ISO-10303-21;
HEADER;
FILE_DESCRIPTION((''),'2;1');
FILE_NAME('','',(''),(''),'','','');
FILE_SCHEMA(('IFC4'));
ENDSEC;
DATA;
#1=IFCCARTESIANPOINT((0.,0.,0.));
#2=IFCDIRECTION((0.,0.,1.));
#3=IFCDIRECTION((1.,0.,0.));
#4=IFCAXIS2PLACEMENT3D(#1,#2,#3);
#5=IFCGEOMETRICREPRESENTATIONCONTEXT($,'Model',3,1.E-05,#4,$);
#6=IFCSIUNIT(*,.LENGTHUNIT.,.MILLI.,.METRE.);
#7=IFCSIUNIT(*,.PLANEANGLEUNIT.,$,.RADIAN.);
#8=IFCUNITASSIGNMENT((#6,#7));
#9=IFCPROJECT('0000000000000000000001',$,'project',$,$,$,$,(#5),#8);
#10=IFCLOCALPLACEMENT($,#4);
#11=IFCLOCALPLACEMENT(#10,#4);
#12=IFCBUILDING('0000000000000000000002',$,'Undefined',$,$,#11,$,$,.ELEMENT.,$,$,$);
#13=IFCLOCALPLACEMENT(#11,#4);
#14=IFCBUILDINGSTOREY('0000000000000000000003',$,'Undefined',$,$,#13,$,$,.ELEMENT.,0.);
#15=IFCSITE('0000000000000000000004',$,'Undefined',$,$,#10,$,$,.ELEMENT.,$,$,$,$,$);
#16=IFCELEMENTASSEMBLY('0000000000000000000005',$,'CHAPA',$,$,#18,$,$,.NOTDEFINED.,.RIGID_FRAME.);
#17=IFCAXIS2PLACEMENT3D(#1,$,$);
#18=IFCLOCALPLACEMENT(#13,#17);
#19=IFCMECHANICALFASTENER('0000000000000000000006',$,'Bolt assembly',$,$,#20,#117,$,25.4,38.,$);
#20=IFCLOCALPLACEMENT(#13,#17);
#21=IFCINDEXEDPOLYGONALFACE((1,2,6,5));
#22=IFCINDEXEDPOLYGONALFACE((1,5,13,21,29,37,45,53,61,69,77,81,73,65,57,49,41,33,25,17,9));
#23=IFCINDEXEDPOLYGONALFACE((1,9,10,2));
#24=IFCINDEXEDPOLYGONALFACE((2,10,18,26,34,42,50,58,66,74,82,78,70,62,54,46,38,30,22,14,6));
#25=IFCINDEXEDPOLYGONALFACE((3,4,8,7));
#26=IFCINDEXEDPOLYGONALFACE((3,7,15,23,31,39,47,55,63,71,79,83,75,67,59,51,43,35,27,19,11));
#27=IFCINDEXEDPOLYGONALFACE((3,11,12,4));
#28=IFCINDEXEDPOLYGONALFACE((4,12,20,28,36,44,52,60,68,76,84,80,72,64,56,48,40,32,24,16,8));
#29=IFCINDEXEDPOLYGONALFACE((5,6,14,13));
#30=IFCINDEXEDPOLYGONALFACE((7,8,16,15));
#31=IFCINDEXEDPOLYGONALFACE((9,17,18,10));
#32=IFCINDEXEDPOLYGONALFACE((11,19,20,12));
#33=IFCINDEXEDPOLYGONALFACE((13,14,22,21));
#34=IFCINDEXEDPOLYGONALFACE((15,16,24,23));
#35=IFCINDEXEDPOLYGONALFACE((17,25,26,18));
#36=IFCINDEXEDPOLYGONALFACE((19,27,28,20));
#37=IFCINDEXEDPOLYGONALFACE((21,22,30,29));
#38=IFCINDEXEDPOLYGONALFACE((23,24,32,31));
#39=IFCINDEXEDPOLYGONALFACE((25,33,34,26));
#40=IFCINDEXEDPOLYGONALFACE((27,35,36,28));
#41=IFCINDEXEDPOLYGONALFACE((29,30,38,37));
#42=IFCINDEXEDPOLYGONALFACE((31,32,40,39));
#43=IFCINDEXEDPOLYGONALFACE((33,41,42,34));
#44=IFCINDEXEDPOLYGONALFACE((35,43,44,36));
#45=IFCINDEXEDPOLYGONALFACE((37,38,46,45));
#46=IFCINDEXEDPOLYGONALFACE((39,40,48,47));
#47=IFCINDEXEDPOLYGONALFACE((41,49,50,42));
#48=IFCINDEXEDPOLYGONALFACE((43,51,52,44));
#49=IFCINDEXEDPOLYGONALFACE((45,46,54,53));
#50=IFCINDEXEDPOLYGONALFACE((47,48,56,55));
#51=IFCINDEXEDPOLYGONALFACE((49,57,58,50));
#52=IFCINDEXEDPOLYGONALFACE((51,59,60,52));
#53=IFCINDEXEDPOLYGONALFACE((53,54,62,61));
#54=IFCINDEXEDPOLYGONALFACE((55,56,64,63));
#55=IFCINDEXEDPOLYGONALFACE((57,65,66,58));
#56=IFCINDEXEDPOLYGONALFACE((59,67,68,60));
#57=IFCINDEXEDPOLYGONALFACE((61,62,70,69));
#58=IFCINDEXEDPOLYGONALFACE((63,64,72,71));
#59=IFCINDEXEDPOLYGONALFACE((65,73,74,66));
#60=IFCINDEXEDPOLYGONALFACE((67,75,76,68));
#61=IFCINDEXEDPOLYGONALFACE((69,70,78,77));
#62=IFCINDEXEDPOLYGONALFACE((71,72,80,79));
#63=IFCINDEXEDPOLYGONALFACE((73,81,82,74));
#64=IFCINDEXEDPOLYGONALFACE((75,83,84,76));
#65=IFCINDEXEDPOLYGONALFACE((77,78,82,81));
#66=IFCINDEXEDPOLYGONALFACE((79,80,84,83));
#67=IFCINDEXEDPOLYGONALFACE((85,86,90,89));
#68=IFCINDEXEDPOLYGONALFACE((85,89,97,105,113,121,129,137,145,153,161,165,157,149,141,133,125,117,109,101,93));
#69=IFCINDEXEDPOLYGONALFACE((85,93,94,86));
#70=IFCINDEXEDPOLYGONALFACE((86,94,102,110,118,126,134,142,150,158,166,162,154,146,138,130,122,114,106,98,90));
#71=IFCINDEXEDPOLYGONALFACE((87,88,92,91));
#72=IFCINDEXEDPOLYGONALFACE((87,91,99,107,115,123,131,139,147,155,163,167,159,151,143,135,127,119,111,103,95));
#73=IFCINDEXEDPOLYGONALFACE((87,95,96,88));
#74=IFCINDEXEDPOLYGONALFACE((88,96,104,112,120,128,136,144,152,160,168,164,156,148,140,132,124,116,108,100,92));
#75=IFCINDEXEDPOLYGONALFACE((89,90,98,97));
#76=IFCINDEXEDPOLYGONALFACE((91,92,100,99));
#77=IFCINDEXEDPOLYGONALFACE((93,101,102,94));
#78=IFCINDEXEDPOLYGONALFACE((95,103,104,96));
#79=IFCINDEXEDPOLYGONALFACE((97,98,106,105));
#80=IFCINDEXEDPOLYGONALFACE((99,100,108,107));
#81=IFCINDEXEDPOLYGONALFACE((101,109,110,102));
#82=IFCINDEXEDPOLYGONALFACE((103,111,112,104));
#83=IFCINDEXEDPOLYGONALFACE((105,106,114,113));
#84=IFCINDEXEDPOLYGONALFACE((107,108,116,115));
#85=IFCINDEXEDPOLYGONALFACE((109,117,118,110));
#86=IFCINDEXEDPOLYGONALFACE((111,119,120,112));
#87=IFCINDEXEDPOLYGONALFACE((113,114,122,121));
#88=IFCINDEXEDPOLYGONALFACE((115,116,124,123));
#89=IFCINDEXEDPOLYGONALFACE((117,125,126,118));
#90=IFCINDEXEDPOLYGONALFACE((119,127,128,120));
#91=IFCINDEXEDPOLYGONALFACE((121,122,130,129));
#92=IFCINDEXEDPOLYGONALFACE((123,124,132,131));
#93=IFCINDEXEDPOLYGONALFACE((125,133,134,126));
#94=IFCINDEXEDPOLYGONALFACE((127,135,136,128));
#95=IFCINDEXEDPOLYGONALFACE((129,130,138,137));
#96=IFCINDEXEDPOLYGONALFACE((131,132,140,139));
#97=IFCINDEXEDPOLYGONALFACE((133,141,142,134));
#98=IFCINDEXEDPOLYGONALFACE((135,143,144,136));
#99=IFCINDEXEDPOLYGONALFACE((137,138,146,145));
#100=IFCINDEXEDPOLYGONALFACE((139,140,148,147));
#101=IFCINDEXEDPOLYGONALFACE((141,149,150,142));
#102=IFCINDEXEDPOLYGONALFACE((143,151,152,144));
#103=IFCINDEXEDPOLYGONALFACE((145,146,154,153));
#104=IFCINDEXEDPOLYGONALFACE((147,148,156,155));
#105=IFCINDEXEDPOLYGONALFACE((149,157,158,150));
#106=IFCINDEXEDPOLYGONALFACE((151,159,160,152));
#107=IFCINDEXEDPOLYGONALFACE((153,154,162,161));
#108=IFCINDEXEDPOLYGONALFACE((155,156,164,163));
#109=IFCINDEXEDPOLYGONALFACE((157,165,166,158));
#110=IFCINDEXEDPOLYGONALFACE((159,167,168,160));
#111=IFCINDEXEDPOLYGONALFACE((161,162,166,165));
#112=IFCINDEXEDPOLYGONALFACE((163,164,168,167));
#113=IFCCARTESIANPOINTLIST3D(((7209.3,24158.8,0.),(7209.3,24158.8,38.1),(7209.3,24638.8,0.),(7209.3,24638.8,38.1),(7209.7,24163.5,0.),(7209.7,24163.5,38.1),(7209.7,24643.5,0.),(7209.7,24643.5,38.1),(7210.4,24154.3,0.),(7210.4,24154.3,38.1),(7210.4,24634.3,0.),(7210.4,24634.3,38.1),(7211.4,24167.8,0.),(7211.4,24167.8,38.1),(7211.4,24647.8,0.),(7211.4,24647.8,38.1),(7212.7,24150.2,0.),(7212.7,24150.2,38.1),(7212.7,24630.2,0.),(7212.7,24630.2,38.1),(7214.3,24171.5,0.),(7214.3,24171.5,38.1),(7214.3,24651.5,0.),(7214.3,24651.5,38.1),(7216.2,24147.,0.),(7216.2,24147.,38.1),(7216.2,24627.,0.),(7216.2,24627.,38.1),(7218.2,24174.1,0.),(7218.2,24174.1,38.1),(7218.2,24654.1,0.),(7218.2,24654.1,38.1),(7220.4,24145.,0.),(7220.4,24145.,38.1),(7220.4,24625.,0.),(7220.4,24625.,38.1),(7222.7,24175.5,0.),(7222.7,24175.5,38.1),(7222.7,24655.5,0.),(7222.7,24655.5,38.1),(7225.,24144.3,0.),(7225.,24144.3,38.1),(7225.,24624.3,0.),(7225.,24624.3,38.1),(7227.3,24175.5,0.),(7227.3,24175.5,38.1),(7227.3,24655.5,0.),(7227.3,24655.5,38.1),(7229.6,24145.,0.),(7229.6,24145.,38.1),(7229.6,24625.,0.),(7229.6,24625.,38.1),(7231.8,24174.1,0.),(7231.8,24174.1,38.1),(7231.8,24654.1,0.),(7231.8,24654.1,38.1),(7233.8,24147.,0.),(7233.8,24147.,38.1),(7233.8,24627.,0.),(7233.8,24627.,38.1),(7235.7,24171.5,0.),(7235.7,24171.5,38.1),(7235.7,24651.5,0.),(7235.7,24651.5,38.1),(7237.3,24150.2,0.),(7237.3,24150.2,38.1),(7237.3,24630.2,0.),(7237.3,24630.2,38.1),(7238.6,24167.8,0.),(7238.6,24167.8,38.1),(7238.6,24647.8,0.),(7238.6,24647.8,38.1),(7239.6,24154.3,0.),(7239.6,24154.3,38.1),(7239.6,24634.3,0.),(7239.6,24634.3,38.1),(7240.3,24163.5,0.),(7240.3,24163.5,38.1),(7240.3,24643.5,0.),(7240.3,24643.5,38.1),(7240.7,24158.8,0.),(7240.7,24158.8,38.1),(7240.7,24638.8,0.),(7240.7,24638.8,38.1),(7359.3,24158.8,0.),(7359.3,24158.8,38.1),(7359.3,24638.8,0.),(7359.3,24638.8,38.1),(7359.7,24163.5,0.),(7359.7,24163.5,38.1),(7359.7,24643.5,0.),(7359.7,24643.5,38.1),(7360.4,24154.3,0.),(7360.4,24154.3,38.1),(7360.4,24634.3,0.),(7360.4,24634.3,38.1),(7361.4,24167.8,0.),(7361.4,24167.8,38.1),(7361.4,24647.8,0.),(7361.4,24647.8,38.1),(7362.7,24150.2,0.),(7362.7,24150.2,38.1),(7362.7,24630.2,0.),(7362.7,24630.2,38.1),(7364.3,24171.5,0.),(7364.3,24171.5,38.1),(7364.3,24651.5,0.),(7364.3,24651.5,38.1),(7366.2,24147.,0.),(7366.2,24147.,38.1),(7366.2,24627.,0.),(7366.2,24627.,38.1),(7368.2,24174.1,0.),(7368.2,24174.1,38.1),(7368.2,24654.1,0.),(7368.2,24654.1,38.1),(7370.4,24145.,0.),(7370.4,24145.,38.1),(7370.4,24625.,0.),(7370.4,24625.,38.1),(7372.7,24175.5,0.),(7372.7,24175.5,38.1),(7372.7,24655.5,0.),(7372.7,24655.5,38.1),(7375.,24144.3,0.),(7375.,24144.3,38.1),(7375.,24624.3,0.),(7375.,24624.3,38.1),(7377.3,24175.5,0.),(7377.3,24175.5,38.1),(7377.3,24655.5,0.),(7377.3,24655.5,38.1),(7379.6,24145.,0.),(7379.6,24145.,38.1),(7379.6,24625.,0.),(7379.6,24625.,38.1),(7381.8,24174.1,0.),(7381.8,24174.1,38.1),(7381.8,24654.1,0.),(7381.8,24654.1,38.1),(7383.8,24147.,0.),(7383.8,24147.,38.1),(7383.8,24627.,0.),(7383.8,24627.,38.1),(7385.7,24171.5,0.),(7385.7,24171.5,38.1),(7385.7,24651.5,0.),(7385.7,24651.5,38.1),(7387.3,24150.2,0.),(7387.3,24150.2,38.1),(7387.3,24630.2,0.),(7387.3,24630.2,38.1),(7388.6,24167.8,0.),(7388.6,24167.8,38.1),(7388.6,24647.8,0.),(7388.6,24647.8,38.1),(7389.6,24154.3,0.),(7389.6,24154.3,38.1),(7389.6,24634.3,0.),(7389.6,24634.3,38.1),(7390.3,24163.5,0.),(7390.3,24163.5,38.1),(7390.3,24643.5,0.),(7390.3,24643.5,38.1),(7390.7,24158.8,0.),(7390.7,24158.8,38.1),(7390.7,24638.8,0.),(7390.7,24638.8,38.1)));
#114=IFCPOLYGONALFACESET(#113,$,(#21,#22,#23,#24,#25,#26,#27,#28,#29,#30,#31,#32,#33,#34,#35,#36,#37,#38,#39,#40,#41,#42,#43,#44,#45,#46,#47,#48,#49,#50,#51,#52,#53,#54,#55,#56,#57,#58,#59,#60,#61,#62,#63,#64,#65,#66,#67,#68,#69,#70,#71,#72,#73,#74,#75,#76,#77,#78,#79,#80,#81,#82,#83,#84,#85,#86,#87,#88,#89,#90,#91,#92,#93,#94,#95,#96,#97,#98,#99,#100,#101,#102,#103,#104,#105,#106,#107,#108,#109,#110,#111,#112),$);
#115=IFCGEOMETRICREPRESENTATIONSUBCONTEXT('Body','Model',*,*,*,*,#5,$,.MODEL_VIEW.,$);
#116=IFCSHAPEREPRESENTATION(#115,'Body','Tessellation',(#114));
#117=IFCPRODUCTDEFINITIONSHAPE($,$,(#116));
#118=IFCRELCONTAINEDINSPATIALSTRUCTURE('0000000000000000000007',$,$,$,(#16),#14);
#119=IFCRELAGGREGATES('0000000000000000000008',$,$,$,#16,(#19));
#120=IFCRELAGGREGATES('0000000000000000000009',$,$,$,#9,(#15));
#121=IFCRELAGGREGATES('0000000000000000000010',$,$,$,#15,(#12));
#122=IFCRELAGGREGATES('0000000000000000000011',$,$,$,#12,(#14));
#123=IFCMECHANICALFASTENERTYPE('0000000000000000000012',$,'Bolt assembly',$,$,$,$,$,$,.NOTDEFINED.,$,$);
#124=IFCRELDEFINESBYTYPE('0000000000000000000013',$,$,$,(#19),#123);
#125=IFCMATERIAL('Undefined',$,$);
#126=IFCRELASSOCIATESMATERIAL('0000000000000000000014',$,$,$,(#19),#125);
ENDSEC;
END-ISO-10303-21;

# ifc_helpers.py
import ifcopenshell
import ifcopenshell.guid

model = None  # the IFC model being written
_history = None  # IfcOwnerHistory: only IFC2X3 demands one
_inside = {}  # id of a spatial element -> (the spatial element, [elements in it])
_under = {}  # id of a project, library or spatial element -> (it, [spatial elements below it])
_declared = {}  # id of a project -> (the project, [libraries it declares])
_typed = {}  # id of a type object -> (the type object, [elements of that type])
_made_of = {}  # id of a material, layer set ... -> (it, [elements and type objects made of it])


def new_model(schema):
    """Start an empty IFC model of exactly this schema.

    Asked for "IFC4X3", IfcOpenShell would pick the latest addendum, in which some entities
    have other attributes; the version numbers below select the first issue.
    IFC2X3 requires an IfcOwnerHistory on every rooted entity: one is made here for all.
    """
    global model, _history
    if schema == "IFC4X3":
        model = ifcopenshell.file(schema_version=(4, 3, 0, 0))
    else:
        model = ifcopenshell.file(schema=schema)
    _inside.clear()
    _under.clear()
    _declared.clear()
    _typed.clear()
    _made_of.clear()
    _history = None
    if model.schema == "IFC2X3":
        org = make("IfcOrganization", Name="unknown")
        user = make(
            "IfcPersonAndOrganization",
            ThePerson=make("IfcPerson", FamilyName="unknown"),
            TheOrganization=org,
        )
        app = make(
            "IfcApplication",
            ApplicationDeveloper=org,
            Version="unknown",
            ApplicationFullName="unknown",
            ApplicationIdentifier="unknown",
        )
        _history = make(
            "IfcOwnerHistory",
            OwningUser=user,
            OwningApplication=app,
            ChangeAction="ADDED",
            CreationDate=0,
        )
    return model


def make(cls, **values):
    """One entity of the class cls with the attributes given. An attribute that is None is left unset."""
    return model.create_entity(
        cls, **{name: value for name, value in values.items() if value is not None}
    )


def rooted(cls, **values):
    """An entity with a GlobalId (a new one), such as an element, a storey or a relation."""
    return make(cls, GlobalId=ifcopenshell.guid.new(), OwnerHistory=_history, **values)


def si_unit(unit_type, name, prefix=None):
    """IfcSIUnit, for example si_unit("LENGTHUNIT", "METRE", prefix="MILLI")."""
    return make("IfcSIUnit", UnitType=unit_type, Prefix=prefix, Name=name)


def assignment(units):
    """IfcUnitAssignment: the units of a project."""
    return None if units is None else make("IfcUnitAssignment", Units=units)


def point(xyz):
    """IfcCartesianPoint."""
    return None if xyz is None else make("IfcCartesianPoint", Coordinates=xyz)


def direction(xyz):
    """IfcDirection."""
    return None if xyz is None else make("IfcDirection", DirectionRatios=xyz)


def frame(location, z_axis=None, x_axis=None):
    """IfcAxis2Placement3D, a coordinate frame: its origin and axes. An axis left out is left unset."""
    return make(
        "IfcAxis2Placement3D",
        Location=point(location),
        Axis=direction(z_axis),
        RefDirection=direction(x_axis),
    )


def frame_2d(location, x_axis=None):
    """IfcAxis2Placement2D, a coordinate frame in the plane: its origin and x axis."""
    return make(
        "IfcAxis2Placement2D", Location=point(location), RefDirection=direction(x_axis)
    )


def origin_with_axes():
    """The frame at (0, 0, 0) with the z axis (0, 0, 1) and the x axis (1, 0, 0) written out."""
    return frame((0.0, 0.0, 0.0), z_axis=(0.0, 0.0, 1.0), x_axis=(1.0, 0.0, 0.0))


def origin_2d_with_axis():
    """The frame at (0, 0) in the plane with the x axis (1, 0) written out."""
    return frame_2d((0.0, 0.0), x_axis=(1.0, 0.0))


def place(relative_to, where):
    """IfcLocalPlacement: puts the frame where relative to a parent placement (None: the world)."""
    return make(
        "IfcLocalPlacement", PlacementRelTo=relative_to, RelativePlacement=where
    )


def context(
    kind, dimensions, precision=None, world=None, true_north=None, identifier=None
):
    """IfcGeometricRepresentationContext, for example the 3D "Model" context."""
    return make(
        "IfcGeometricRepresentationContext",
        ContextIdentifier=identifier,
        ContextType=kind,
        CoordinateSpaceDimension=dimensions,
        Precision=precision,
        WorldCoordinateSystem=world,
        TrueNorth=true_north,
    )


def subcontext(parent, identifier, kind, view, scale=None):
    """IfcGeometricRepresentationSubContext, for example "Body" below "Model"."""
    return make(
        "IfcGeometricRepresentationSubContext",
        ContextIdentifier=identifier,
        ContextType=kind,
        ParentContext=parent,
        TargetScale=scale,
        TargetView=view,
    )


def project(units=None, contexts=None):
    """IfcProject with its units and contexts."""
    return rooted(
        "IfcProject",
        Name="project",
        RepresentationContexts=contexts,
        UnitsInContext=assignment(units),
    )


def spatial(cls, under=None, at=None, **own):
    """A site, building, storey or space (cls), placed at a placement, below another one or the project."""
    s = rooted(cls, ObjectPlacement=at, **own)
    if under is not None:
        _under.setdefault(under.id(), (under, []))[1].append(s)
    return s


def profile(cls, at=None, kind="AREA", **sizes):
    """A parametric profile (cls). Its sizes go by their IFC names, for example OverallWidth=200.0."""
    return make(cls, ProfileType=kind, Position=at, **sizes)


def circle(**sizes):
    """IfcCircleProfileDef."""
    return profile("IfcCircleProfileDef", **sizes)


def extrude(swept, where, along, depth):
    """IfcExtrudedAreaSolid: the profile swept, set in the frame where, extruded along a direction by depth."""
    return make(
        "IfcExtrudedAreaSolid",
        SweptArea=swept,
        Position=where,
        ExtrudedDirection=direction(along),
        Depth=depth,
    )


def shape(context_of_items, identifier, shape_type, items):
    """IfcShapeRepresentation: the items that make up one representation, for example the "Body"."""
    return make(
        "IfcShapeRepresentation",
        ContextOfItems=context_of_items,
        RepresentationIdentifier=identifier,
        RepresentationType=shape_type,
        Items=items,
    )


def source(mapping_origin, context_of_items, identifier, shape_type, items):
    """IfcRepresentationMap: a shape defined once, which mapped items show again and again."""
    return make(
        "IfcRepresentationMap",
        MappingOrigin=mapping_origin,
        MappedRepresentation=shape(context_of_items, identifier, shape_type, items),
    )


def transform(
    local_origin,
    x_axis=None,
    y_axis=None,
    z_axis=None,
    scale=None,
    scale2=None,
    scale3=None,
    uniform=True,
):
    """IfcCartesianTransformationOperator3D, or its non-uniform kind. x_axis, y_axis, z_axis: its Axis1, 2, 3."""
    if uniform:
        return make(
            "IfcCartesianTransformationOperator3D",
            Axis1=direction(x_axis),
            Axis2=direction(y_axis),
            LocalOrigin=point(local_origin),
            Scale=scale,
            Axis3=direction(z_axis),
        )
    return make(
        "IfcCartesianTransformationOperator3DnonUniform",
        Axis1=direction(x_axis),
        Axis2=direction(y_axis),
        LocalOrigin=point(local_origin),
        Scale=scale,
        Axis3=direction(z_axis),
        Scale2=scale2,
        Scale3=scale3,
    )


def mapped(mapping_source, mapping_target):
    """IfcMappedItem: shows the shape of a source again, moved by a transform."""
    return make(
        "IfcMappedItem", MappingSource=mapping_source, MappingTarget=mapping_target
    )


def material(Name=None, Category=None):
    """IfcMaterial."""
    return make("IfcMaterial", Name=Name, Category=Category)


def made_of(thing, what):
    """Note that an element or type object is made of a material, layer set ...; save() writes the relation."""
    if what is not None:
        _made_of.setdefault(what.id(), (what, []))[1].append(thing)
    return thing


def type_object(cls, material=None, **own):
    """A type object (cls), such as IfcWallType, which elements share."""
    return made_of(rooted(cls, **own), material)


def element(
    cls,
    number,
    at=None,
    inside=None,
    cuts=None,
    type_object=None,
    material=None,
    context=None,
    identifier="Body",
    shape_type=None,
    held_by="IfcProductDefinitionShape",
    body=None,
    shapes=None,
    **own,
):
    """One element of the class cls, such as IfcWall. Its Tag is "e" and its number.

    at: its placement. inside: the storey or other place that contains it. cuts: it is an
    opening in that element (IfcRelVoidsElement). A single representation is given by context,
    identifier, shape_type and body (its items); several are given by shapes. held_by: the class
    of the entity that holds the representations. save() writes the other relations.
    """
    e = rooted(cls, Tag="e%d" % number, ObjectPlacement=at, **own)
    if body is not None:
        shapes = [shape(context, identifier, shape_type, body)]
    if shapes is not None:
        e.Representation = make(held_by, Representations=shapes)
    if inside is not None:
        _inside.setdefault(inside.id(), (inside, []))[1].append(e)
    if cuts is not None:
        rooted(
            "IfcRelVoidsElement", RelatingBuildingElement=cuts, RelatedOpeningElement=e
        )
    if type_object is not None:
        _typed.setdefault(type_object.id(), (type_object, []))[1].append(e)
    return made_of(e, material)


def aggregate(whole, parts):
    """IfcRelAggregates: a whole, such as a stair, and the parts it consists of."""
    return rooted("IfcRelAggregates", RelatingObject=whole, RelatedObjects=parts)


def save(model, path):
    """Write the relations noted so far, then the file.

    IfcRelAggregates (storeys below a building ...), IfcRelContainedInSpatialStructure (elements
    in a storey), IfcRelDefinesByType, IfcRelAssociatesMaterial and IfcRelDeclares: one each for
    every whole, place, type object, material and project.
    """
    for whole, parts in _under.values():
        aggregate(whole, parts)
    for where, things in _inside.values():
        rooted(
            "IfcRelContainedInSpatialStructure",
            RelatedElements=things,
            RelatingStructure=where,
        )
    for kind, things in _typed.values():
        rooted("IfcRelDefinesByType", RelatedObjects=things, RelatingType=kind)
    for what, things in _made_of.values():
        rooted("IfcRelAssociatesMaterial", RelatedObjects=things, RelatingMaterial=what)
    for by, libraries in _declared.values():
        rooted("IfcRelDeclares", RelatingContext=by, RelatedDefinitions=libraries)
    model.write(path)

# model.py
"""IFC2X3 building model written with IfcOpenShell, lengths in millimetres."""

from ifc_helpers import new_model, si_unit, frame, origin_with_axes, origin_2d_with_axis, place, context, subcontext, project, spatial, circle, extrude, source, transform, mapped, material, type_object, element, aggregate, save


model = new_model("IFC2X3")

# Units and contexts
model_context = context("Model", 3, precision=1e-05, world=origin_with_axes())
body_context = subcontext(model_context, "Body", "Model", "MODEL_VIEW")
ifc_project = project(units=[si_unit("LENGTHUNIT", "METRE", prefix="MILLI"), si_unit("PLANEANGLEUNIT", "RADIAN")], contexts=[model_context])

# Site, building, storey
site_placement = place(None, origin_with_axes())
site = spatial("IfcSite", under=ifc_project, at=site_placement, Name="Undefined", CompositionType="ELEMENT")
building_placement = place(site_placement, origin_with_axes())
building = spatial("IfcBuilding", under=site, at=building_placement, Name="Undefined", CompositionType="ELEMENT")
storey_placement = place(building_placement, origin_with_axes())
storey = spatial("IfcBuildingStorey", under=building, at=storey_placement, Name="Undefined", CompositionType="ELEMENT", Elevation=0.0)

# Element assembly
assembly_1_placement = place(storey_placement, origin_with_axes())
assembly_1 = element("IfcElementAssembly", 1, at=assembly_1_placement, inside=storey, Name="CHAPA", AssemblyPlace="NOTDEFINED", PredefinedType="RIGID_FRAME")

# Shared definitions
ifc_material_1 = material(Name="Undefined")
mechanical_fastener_type = type_object("IfcMechanicalFastenerType", Name="Bolt assembly")

# Mechanical fastener
shared_shape_1 = source(origin_with_axes(), body_context, "Body", "SweptSolid", [
    extrude(circle(Radius=15.7, at=origin_2d_with_axis()), frame((0.0, -38.0, 0.0), z_axis=(0.0, 1.0, 0.0), x_axis=(1.0, 0.0, 0.0)), (0.0, 0.0, 1.0), 38.1),
])
mechanical_fastener_1_placement = place(assembly_1_placement, frame((7300.0, 24640.0, 38.0), z_axis=(-1.0, 0.0, 0.0), x_axis=(0.0, -1.0, 0.0)))
mechanical_fastener_1 = element("IfcMechanicalFastener", 2, at=mechanical_fastener_1_placement, type_object=mechanical_fastener_type, material=ifc_material_1, Name="Bolt assembly", NominalDiameter=25.4, NominalLength=38.0, context=body_context, shape_type="MappedRepresentation", body=[
    mapped(shared_shape_1, transform((0.0, 0.0, -75.0))),
    mapped(shared_shape_1, transform((0.0, 0.0, 75.0))),
    mapped(shared_shape_1, transform((480.0, 0.0, -75.0))),
    mapped(shared_shape_1, transform((480.0, 0.0, 75.0))),
])
aggregate(assembly_1, [mechanical_fastener_1])

save(model, "model.ifc")
